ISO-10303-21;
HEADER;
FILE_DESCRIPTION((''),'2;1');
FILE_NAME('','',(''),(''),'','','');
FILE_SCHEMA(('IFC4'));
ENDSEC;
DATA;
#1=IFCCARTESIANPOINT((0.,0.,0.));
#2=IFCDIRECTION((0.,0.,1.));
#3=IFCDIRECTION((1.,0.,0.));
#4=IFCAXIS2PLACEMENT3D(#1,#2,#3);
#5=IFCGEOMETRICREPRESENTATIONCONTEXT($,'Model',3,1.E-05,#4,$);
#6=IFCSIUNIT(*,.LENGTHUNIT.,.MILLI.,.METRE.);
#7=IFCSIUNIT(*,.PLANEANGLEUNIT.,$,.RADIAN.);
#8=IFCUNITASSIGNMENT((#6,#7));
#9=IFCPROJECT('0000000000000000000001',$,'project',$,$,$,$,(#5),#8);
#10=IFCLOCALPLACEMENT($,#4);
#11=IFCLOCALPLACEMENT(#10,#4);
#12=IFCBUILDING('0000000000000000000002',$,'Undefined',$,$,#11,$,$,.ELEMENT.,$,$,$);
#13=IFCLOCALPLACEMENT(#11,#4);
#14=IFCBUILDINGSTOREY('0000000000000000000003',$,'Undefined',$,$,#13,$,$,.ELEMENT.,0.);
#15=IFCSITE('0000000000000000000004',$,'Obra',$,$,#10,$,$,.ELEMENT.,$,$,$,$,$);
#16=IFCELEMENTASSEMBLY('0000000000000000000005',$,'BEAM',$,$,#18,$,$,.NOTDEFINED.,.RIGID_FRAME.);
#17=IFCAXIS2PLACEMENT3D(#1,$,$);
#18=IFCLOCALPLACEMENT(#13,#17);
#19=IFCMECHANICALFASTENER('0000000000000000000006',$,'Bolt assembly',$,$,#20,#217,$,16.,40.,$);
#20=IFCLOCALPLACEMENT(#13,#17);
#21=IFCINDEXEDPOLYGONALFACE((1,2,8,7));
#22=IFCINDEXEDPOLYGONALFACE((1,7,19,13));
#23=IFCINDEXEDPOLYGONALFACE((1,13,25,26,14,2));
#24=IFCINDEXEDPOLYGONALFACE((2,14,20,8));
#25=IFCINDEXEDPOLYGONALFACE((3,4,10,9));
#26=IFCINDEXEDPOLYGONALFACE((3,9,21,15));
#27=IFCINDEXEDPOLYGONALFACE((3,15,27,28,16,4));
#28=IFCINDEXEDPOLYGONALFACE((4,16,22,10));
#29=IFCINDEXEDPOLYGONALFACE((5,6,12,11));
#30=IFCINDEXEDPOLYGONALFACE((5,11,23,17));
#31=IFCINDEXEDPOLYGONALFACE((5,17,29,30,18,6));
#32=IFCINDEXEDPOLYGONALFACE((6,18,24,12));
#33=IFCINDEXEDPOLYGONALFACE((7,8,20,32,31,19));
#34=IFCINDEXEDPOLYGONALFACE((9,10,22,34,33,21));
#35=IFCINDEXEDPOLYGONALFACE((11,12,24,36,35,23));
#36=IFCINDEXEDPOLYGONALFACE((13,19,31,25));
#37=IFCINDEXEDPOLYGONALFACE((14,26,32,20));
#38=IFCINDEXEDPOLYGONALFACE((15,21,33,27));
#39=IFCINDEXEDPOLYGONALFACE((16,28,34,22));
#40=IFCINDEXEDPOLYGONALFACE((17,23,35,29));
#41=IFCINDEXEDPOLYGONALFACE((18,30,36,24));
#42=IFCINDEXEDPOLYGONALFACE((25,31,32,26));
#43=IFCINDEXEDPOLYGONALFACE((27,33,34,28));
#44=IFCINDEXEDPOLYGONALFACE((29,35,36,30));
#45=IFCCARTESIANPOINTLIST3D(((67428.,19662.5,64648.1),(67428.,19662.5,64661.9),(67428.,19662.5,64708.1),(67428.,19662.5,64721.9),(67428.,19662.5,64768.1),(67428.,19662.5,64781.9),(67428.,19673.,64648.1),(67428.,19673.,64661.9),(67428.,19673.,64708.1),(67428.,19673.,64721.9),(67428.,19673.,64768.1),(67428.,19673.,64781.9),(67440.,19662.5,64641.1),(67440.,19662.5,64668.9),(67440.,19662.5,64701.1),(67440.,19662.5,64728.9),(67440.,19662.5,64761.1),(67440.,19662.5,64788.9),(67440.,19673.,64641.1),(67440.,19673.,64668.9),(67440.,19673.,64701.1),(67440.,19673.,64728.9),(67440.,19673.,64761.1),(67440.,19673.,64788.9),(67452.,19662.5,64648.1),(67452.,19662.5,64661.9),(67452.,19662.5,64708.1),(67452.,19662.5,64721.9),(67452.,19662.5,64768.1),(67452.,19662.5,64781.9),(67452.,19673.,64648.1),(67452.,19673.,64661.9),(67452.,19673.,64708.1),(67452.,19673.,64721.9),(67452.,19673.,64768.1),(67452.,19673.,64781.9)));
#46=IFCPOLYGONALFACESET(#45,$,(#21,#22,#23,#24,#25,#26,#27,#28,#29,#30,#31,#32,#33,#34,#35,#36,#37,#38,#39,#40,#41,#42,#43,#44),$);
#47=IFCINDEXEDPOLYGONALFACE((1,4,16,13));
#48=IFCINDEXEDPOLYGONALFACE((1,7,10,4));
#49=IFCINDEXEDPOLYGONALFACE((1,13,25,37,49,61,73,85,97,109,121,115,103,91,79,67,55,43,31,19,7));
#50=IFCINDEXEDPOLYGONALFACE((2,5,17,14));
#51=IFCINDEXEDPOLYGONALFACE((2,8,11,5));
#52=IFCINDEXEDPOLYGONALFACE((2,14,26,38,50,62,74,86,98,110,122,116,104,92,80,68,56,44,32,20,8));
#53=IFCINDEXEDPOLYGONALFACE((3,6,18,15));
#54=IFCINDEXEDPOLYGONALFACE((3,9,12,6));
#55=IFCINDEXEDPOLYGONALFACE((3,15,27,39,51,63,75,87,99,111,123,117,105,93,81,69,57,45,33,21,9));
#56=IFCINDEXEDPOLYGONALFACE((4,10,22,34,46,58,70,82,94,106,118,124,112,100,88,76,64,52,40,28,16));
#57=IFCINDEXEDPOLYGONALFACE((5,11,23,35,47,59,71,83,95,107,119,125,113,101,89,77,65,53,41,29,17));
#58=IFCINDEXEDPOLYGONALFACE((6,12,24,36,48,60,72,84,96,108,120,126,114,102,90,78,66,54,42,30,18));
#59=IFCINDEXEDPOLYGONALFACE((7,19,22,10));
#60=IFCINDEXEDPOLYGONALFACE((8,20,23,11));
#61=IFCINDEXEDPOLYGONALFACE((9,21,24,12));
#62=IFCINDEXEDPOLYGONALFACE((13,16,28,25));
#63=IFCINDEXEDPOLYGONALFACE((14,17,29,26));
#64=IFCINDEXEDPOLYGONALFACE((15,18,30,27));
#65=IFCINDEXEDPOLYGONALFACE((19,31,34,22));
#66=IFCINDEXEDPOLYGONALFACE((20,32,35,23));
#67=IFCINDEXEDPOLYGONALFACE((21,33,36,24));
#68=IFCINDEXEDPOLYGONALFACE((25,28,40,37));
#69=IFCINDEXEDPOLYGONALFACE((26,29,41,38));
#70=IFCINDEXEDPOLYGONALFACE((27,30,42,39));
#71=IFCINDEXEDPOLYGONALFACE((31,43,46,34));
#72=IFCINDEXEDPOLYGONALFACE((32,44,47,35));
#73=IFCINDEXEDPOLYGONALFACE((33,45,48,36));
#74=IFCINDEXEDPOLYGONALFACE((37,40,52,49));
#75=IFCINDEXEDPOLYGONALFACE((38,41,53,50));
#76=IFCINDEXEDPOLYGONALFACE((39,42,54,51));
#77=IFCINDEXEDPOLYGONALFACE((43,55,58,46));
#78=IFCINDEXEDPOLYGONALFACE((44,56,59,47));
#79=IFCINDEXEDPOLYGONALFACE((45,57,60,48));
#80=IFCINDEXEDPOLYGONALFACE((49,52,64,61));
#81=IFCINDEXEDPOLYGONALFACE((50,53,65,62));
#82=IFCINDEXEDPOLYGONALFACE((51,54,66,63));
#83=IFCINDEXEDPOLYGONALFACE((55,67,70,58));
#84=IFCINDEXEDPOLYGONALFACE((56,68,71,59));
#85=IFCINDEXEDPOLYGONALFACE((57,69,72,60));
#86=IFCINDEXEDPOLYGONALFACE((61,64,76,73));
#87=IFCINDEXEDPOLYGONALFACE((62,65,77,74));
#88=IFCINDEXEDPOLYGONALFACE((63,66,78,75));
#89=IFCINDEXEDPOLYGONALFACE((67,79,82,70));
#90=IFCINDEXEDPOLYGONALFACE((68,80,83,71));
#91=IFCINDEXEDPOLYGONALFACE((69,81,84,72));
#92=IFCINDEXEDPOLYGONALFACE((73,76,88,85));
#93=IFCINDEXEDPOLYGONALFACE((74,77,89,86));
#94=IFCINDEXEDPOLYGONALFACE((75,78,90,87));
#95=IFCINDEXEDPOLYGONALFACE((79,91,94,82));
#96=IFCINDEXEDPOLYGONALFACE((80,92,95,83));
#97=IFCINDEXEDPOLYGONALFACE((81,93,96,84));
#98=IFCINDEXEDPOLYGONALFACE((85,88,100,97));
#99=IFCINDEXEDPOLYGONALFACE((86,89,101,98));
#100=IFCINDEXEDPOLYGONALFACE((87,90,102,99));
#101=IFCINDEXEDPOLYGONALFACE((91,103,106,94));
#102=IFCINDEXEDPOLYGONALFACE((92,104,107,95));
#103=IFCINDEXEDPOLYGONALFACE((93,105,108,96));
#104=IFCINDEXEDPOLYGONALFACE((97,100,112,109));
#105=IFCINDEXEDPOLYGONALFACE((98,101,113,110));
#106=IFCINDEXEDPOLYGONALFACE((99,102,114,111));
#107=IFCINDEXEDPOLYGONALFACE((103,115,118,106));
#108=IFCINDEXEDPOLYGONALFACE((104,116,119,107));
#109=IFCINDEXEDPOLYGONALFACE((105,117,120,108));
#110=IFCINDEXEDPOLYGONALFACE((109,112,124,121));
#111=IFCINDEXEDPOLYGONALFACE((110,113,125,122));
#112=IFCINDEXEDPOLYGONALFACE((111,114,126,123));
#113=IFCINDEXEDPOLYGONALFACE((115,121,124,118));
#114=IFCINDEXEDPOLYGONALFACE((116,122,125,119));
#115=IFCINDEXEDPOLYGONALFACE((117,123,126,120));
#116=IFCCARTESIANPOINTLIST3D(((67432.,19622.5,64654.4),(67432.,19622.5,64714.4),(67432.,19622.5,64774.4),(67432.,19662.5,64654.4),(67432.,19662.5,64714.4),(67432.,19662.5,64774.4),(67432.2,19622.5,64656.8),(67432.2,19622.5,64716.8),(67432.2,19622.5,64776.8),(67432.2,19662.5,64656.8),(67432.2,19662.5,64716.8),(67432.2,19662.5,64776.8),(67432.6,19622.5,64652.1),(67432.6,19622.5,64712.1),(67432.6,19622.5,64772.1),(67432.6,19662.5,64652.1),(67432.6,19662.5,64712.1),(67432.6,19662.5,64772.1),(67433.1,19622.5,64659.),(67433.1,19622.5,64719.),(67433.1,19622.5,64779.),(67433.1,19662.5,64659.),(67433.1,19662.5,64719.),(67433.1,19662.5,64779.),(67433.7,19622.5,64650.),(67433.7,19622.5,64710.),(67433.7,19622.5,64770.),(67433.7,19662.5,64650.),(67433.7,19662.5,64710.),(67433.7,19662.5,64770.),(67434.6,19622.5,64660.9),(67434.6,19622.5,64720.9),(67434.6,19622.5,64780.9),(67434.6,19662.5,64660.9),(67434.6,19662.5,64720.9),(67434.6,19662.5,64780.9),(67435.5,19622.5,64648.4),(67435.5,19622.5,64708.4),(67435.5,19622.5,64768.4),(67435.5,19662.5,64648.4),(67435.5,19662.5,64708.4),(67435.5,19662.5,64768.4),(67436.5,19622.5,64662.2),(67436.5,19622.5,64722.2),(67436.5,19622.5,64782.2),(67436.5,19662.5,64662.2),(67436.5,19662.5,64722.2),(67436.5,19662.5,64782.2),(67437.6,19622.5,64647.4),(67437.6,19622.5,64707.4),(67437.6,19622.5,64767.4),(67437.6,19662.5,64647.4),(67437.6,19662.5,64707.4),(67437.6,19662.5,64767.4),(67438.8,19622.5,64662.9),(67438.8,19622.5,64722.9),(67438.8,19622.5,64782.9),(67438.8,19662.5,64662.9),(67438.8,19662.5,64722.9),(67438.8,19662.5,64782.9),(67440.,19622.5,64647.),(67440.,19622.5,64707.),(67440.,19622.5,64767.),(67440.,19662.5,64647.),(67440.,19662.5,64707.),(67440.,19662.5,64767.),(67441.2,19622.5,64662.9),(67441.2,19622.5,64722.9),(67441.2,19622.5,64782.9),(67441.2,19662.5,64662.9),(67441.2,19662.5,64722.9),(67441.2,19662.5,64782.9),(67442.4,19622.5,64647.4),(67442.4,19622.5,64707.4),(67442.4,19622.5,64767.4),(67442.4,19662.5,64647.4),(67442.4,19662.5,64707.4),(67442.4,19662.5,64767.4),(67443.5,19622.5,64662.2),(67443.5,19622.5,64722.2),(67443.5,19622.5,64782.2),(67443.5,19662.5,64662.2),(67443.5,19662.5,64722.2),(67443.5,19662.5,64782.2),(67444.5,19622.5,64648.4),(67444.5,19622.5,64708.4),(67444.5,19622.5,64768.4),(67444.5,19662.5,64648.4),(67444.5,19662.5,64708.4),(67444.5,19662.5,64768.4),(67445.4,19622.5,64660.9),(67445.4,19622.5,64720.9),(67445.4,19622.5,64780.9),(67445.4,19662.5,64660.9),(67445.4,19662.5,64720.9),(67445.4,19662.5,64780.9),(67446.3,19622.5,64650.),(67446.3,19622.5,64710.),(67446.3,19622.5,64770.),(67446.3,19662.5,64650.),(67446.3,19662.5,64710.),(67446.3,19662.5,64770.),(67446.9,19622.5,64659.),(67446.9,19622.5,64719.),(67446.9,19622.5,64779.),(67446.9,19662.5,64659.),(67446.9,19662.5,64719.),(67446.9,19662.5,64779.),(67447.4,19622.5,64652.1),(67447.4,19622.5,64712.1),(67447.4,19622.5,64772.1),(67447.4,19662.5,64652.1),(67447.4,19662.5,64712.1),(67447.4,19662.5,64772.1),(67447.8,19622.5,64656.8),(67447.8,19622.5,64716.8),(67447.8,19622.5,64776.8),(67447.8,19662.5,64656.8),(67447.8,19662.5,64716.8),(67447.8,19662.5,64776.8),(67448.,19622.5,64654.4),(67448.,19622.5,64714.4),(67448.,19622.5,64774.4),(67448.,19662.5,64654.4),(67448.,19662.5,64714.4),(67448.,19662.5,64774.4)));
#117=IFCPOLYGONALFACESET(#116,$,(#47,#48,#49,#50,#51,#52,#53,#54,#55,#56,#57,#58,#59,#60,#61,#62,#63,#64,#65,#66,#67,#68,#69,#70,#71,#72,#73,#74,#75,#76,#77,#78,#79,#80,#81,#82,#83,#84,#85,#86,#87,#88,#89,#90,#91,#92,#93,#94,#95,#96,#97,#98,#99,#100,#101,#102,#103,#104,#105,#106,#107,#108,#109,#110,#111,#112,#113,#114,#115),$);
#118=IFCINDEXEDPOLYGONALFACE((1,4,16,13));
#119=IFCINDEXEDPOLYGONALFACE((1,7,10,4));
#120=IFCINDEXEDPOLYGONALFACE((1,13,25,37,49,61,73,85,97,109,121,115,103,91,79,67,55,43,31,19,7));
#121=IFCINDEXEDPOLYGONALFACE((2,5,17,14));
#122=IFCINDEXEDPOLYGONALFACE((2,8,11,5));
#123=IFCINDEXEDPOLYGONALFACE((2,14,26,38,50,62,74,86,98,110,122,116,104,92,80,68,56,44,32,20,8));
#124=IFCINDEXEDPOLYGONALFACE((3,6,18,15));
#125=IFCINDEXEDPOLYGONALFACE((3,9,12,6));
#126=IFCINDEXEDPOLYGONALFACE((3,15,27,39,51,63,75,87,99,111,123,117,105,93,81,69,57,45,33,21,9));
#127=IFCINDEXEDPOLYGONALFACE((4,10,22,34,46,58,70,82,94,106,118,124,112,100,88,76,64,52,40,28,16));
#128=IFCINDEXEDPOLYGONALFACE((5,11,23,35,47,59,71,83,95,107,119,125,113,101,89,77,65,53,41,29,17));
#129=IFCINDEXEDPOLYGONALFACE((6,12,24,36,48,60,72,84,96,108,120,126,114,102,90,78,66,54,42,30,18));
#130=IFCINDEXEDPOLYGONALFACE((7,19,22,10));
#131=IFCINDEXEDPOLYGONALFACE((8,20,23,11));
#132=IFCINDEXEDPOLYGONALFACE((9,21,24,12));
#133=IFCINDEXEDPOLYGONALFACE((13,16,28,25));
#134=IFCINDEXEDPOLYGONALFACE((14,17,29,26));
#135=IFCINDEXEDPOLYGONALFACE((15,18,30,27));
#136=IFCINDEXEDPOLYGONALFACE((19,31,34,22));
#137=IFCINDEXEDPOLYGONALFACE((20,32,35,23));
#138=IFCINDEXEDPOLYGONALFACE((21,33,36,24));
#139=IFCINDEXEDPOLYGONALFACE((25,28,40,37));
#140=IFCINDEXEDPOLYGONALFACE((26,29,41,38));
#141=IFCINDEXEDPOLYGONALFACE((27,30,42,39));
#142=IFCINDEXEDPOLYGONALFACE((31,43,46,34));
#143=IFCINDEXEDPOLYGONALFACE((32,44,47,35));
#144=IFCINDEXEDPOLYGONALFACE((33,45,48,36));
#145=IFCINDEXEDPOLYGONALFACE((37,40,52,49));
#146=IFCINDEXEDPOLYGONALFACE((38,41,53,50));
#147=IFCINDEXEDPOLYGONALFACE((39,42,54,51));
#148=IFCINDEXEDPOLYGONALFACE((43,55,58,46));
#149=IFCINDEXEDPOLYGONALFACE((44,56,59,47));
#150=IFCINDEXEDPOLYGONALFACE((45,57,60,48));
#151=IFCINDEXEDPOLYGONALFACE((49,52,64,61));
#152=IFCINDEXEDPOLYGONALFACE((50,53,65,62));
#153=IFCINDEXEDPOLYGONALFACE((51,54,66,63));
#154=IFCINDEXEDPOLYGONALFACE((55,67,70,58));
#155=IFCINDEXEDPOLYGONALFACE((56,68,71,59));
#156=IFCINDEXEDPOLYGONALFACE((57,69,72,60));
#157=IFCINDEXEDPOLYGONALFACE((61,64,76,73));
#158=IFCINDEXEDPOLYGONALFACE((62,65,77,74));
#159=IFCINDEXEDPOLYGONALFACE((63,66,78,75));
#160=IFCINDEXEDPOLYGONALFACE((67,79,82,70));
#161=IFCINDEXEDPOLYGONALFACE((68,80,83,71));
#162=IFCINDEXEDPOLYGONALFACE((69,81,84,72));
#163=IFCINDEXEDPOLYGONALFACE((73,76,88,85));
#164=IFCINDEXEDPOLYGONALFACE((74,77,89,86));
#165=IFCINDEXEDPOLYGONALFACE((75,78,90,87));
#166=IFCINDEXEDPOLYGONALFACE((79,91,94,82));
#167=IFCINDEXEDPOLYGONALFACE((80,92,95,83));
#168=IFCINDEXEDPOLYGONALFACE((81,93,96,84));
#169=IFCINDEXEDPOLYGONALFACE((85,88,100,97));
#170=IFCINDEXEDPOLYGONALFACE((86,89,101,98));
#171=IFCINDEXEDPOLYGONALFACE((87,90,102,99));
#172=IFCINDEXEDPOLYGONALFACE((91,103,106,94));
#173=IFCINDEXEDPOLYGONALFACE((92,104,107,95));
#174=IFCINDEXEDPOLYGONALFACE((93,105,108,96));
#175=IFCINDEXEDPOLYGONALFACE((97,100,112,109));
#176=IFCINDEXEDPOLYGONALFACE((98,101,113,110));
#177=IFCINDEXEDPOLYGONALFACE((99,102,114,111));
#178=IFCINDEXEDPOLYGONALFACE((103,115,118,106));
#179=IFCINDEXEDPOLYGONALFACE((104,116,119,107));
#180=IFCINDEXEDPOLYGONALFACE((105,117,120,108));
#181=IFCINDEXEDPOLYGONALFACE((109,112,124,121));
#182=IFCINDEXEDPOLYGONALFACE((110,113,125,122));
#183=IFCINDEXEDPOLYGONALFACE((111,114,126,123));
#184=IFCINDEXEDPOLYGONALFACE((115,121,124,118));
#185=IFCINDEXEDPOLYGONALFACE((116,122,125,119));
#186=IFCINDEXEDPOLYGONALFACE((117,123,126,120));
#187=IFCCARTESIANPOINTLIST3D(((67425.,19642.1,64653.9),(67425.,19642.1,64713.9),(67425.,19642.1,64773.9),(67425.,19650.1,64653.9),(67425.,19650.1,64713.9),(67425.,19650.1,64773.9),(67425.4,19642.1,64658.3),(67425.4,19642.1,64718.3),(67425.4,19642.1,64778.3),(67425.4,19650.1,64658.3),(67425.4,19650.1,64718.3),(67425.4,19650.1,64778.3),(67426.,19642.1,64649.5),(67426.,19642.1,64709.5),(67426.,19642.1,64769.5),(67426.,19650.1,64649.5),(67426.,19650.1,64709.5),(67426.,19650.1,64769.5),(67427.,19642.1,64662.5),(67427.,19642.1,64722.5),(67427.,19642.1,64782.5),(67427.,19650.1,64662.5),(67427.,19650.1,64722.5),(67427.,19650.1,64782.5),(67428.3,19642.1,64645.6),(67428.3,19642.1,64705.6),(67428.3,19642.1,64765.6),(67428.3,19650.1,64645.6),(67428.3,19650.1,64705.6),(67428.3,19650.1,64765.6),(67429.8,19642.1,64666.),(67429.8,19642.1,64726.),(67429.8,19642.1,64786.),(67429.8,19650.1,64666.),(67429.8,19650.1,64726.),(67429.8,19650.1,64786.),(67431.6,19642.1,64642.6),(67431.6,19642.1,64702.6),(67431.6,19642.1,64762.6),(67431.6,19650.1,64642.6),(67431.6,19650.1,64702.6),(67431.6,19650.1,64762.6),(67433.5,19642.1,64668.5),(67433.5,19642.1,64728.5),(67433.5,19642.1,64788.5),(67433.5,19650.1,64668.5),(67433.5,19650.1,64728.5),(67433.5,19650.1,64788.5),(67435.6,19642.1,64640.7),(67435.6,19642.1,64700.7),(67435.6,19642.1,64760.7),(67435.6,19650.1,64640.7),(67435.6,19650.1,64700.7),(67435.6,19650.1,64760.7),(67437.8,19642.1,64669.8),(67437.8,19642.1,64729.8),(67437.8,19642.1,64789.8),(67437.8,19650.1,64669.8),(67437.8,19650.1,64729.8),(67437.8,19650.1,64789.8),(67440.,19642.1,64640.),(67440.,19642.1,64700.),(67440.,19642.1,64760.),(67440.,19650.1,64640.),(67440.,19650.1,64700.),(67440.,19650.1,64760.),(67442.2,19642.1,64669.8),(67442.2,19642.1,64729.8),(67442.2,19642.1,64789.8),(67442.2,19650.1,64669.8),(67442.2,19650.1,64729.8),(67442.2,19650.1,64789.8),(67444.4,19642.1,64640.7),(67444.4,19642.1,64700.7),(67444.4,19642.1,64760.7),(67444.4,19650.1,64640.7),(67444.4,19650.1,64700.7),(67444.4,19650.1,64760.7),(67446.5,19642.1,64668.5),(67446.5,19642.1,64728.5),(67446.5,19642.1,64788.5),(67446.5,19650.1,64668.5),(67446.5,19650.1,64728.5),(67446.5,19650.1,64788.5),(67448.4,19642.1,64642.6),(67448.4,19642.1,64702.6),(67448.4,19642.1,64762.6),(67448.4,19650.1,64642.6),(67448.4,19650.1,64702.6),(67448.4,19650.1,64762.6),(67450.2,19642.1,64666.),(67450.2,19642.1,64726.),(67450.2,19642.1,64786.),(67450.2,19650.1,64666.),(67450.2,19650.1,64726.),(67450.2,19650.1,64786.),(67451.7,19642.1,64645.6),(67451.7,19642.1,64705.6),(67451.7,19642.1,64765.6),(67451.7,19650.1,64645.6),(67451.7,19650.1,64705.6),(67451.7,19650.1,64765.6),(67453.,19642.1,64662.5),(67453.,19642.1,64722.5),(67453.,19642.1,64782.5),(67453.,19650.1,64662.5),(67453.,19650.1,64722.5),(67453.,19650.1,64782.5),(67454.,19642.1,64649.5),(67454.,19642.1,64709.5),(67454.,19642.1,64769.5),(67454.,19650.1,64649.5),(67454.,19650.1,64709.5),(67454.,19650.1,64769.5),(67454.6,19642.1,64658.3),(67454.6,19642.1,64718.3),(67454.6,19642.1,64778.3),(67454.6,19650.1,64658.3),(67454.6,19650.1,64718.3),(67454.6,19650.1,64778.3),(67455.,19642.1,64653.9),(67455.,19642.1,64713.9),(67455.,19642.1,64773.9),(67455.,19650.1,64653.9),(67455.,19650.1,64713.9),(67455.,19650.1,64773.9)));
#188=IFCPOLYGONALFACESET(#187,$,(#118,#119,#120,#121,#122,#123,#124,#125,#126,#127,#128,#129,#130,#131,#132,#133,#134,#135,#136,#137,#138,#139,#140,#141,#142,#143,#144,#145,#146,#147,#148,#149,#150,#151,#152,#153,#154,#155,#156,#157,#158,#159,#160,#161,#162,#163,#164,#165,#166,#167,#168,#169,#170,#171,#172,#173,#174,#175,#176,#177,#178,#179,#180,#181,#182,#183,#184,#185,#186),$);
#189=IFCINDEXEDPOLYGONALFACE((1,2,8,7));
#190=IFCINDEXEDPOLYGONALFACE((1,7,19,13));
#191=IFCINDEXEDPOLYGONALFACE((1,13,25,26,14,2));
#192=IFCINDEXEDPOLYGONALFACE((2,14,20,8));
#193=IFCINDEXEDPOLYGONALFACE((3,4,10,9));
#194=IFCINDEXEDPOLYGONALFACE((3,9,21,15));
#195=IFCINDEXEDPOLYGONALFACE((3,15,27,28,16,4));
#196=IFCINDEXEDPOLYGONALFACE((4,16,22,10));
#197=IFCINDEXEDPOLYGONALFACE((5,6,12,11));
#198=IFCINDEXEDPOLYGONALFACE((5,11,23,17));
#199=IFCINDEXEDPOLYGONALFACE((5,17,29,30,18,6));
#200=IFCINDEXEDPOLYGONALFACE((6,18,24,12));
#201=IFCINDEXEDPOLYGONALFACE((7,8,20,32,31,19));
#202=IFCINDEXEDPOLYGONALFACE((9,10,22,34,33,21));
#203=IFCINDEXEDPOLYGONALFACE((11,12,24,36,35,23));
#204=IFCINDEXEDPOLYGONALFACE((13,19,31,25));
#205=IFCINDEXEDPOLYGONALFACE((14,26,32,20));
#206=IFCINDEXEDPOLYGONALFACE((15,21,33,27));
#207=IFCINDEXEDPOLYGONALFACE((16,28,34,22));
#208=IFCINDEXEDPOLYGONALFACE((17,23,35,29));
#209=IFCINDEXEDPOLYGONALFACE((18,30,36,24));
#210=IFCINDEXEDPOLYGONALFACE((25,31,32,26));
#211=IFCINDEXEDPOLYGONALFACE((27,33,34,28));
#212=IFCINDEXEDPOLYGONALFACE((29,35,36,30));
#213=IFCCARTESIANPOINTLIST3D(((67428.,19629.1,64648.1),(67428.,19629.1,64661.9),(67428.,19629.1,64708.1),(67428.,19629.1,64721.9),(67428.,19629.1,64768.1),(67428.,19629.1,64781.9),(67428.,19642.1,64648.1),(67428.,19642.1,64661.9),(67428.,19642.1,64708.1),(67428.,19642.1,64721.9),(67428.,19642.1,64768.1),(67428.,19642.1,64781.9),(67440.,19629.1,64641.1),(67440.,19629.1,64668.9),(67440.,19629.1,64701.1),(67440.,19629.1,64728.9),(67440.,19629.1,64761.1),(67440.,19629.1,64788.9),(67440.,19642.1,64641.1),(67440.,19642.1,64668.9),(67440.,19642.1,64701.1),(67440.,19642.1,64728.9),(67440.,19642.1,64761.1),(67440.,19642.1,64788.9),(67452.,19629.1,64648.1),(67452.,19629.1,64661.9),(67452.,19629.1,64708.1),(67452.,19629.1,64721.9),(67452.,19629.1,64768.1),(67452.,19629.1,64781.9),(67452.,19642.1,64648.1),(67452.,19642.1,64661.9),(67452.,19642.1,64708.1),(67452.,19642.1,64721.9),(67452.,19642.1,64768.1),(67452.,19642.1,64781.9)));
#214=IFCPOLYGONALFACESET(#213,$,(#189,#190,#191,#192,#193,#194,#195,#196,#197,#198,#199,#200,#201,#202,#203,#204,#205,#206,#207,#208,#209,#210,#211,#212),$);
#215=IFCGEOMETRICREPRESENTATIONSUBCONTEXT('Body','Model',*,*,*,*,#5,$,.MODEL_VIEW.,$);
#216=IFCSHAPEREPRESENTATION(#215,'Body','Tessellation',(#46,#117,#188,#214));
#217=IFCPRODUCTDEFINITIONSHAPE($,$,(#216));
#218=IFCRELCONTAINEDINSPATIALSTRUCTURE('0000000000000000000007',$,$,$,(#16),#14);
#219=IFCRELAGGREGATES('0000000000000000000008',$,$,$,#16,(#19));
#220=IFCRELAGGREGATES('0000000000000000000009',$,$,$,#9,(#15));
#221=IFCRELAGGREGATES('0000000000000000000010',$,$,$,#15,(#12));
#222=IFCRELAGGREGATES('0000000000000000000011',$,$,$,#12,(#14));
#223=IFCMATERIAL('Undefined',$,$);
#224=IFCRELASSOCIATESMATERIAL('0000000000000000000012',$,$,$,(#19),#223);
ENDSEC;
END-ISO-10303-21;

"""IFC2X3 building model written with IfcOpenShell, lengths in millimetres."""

from ifc_helpers import new_model, si_unit, frame, origin_with_axes, origin_2d_with_axis, place, context, subcontext, project, spatial, polyline, circle, outline, extrude, source, transform, mapped, material, element, aggregate, save


model = new_model("IFC2X3")

# Units and contexts
model_context = context("Model", 3, precision=1e-05, world=origin_with_axes())
body_context = subcontext(model_context, "Body", "Model", "MODEL_VIEW")
ifc_project = project(units=[si_unit("LENGTHUNIT", "METRE", prefix="MILLI"), si_unit("PLANEANGLEUNIT", "RADIAN")], contexts=[model_context])

# Site, building, storey
site_placement = place(None, origin_with_axes())
site = spatial("IfcSite", under=ifc_project, at=site_placement, Name="Obra", CompositionType="ELEMENT")
building_placement = place(site_placement, origin_with_axes())
building = spatial("IfcBuilding", under=site, at=building_placement, Name="Undefined", CompositionType="ELEMENT")
storey_placement = place(building_placement, origin_with_axes())
storey = spatial("IfcBuildingStorey", under=building, at=storey_placement, Name="Undefined", CompositionType="ELEMENT", Elevation=0.0)

# Element assembly, mechanical fastener
assembly_1_placement = place(storey_placement, origin_with_axes())
assembly_1 = element("IfcElementAssembly", 1, at=assembly_1_placement, inside=storey, Name="BEAM", AssemblyPlace="NOTDEFINED", PredefinedType="RIGID_FRAME")
ifc_material_1 = material(Name="Undefined")
shared_shape_1 = source(origin_with_axes(), body_context, "Body", "SweptSolid", [
    extrude(outline(polyline([(13.9, 0.0), (6.9, 12.0), (-6.9, 12.0), (-13.9, 0.0), (-6.9, -12.0), (6.9, -12.0), (13.9, 0.0)])), frame((0.0, -19.7, 0.0), z_axis=(0.0, 1.0, 0.0), x_axis=(1.0, 0.0, 0.0)), (0.0, 0.0, 1.0), 10.6),
    extrude(circle(Radius=8.0, at=origin_2d_with_axis()), frame((0.0, -9.1, 0.0), z_axis=(0.0, 1.0, 0.0), x_axis=(1.0, 0.0, 0.0)), (0.0, 0.0, 1.0), 40.0),
    extrude(circle(Radius=15.0, at=origin_2d_with_axis()), frame((0.0, 3.3, 0.0), z_axis=(0.0, 1.0, 0.0), x_axis=(1.0, 0.0, 0.0)), (0.0, 0.0, 1.0), 8.0),
    extrude(outline(polyline([(13.9, 0.0), (6.9, 12.0), (-6.9, 12.0), (-13.9, 0.0), (-6.9, -12.0), (6.9, -12.0), (13.9, 0.0)])), frame((0.0, 11.3, 0.0), z_axis=(0.0, 1.0, 0.0), x_axis=(1.0, 0.0, 0.0)), (0.0, 0.0, 1.0), 13.0),
])
mechanical_fastener_1_placement = place(assembly_1_placement, frame((67490.0, 19653.4, 64835.0), z_axis=(-1.0, 0.0, 0.0), x_axis=(0.0, 0.0, -1.0)))
mechanical_fastener_1 = element("IfcMechanicalFastener", 2, at=mechanical_fastener_1_placement, material=ifc_material_1, Name="Bolt assembly", NominalDiameter=16.0, NominalLength=40.0, context=body_context, shape_type="MappedRepresentation", body=[
    mapped(shared_shape_1, transform((60.0, 0.0, 50.0))),
    mapped(shared_shape_1, transform((120.0, 0.0, 50.0))),
    mapped(shared_shape_1, transform((180.0, 0.0, 50.0))),
])
aggregate(assembly_1, [mechanical_fastener_1])

save(model, "model.ifc")
